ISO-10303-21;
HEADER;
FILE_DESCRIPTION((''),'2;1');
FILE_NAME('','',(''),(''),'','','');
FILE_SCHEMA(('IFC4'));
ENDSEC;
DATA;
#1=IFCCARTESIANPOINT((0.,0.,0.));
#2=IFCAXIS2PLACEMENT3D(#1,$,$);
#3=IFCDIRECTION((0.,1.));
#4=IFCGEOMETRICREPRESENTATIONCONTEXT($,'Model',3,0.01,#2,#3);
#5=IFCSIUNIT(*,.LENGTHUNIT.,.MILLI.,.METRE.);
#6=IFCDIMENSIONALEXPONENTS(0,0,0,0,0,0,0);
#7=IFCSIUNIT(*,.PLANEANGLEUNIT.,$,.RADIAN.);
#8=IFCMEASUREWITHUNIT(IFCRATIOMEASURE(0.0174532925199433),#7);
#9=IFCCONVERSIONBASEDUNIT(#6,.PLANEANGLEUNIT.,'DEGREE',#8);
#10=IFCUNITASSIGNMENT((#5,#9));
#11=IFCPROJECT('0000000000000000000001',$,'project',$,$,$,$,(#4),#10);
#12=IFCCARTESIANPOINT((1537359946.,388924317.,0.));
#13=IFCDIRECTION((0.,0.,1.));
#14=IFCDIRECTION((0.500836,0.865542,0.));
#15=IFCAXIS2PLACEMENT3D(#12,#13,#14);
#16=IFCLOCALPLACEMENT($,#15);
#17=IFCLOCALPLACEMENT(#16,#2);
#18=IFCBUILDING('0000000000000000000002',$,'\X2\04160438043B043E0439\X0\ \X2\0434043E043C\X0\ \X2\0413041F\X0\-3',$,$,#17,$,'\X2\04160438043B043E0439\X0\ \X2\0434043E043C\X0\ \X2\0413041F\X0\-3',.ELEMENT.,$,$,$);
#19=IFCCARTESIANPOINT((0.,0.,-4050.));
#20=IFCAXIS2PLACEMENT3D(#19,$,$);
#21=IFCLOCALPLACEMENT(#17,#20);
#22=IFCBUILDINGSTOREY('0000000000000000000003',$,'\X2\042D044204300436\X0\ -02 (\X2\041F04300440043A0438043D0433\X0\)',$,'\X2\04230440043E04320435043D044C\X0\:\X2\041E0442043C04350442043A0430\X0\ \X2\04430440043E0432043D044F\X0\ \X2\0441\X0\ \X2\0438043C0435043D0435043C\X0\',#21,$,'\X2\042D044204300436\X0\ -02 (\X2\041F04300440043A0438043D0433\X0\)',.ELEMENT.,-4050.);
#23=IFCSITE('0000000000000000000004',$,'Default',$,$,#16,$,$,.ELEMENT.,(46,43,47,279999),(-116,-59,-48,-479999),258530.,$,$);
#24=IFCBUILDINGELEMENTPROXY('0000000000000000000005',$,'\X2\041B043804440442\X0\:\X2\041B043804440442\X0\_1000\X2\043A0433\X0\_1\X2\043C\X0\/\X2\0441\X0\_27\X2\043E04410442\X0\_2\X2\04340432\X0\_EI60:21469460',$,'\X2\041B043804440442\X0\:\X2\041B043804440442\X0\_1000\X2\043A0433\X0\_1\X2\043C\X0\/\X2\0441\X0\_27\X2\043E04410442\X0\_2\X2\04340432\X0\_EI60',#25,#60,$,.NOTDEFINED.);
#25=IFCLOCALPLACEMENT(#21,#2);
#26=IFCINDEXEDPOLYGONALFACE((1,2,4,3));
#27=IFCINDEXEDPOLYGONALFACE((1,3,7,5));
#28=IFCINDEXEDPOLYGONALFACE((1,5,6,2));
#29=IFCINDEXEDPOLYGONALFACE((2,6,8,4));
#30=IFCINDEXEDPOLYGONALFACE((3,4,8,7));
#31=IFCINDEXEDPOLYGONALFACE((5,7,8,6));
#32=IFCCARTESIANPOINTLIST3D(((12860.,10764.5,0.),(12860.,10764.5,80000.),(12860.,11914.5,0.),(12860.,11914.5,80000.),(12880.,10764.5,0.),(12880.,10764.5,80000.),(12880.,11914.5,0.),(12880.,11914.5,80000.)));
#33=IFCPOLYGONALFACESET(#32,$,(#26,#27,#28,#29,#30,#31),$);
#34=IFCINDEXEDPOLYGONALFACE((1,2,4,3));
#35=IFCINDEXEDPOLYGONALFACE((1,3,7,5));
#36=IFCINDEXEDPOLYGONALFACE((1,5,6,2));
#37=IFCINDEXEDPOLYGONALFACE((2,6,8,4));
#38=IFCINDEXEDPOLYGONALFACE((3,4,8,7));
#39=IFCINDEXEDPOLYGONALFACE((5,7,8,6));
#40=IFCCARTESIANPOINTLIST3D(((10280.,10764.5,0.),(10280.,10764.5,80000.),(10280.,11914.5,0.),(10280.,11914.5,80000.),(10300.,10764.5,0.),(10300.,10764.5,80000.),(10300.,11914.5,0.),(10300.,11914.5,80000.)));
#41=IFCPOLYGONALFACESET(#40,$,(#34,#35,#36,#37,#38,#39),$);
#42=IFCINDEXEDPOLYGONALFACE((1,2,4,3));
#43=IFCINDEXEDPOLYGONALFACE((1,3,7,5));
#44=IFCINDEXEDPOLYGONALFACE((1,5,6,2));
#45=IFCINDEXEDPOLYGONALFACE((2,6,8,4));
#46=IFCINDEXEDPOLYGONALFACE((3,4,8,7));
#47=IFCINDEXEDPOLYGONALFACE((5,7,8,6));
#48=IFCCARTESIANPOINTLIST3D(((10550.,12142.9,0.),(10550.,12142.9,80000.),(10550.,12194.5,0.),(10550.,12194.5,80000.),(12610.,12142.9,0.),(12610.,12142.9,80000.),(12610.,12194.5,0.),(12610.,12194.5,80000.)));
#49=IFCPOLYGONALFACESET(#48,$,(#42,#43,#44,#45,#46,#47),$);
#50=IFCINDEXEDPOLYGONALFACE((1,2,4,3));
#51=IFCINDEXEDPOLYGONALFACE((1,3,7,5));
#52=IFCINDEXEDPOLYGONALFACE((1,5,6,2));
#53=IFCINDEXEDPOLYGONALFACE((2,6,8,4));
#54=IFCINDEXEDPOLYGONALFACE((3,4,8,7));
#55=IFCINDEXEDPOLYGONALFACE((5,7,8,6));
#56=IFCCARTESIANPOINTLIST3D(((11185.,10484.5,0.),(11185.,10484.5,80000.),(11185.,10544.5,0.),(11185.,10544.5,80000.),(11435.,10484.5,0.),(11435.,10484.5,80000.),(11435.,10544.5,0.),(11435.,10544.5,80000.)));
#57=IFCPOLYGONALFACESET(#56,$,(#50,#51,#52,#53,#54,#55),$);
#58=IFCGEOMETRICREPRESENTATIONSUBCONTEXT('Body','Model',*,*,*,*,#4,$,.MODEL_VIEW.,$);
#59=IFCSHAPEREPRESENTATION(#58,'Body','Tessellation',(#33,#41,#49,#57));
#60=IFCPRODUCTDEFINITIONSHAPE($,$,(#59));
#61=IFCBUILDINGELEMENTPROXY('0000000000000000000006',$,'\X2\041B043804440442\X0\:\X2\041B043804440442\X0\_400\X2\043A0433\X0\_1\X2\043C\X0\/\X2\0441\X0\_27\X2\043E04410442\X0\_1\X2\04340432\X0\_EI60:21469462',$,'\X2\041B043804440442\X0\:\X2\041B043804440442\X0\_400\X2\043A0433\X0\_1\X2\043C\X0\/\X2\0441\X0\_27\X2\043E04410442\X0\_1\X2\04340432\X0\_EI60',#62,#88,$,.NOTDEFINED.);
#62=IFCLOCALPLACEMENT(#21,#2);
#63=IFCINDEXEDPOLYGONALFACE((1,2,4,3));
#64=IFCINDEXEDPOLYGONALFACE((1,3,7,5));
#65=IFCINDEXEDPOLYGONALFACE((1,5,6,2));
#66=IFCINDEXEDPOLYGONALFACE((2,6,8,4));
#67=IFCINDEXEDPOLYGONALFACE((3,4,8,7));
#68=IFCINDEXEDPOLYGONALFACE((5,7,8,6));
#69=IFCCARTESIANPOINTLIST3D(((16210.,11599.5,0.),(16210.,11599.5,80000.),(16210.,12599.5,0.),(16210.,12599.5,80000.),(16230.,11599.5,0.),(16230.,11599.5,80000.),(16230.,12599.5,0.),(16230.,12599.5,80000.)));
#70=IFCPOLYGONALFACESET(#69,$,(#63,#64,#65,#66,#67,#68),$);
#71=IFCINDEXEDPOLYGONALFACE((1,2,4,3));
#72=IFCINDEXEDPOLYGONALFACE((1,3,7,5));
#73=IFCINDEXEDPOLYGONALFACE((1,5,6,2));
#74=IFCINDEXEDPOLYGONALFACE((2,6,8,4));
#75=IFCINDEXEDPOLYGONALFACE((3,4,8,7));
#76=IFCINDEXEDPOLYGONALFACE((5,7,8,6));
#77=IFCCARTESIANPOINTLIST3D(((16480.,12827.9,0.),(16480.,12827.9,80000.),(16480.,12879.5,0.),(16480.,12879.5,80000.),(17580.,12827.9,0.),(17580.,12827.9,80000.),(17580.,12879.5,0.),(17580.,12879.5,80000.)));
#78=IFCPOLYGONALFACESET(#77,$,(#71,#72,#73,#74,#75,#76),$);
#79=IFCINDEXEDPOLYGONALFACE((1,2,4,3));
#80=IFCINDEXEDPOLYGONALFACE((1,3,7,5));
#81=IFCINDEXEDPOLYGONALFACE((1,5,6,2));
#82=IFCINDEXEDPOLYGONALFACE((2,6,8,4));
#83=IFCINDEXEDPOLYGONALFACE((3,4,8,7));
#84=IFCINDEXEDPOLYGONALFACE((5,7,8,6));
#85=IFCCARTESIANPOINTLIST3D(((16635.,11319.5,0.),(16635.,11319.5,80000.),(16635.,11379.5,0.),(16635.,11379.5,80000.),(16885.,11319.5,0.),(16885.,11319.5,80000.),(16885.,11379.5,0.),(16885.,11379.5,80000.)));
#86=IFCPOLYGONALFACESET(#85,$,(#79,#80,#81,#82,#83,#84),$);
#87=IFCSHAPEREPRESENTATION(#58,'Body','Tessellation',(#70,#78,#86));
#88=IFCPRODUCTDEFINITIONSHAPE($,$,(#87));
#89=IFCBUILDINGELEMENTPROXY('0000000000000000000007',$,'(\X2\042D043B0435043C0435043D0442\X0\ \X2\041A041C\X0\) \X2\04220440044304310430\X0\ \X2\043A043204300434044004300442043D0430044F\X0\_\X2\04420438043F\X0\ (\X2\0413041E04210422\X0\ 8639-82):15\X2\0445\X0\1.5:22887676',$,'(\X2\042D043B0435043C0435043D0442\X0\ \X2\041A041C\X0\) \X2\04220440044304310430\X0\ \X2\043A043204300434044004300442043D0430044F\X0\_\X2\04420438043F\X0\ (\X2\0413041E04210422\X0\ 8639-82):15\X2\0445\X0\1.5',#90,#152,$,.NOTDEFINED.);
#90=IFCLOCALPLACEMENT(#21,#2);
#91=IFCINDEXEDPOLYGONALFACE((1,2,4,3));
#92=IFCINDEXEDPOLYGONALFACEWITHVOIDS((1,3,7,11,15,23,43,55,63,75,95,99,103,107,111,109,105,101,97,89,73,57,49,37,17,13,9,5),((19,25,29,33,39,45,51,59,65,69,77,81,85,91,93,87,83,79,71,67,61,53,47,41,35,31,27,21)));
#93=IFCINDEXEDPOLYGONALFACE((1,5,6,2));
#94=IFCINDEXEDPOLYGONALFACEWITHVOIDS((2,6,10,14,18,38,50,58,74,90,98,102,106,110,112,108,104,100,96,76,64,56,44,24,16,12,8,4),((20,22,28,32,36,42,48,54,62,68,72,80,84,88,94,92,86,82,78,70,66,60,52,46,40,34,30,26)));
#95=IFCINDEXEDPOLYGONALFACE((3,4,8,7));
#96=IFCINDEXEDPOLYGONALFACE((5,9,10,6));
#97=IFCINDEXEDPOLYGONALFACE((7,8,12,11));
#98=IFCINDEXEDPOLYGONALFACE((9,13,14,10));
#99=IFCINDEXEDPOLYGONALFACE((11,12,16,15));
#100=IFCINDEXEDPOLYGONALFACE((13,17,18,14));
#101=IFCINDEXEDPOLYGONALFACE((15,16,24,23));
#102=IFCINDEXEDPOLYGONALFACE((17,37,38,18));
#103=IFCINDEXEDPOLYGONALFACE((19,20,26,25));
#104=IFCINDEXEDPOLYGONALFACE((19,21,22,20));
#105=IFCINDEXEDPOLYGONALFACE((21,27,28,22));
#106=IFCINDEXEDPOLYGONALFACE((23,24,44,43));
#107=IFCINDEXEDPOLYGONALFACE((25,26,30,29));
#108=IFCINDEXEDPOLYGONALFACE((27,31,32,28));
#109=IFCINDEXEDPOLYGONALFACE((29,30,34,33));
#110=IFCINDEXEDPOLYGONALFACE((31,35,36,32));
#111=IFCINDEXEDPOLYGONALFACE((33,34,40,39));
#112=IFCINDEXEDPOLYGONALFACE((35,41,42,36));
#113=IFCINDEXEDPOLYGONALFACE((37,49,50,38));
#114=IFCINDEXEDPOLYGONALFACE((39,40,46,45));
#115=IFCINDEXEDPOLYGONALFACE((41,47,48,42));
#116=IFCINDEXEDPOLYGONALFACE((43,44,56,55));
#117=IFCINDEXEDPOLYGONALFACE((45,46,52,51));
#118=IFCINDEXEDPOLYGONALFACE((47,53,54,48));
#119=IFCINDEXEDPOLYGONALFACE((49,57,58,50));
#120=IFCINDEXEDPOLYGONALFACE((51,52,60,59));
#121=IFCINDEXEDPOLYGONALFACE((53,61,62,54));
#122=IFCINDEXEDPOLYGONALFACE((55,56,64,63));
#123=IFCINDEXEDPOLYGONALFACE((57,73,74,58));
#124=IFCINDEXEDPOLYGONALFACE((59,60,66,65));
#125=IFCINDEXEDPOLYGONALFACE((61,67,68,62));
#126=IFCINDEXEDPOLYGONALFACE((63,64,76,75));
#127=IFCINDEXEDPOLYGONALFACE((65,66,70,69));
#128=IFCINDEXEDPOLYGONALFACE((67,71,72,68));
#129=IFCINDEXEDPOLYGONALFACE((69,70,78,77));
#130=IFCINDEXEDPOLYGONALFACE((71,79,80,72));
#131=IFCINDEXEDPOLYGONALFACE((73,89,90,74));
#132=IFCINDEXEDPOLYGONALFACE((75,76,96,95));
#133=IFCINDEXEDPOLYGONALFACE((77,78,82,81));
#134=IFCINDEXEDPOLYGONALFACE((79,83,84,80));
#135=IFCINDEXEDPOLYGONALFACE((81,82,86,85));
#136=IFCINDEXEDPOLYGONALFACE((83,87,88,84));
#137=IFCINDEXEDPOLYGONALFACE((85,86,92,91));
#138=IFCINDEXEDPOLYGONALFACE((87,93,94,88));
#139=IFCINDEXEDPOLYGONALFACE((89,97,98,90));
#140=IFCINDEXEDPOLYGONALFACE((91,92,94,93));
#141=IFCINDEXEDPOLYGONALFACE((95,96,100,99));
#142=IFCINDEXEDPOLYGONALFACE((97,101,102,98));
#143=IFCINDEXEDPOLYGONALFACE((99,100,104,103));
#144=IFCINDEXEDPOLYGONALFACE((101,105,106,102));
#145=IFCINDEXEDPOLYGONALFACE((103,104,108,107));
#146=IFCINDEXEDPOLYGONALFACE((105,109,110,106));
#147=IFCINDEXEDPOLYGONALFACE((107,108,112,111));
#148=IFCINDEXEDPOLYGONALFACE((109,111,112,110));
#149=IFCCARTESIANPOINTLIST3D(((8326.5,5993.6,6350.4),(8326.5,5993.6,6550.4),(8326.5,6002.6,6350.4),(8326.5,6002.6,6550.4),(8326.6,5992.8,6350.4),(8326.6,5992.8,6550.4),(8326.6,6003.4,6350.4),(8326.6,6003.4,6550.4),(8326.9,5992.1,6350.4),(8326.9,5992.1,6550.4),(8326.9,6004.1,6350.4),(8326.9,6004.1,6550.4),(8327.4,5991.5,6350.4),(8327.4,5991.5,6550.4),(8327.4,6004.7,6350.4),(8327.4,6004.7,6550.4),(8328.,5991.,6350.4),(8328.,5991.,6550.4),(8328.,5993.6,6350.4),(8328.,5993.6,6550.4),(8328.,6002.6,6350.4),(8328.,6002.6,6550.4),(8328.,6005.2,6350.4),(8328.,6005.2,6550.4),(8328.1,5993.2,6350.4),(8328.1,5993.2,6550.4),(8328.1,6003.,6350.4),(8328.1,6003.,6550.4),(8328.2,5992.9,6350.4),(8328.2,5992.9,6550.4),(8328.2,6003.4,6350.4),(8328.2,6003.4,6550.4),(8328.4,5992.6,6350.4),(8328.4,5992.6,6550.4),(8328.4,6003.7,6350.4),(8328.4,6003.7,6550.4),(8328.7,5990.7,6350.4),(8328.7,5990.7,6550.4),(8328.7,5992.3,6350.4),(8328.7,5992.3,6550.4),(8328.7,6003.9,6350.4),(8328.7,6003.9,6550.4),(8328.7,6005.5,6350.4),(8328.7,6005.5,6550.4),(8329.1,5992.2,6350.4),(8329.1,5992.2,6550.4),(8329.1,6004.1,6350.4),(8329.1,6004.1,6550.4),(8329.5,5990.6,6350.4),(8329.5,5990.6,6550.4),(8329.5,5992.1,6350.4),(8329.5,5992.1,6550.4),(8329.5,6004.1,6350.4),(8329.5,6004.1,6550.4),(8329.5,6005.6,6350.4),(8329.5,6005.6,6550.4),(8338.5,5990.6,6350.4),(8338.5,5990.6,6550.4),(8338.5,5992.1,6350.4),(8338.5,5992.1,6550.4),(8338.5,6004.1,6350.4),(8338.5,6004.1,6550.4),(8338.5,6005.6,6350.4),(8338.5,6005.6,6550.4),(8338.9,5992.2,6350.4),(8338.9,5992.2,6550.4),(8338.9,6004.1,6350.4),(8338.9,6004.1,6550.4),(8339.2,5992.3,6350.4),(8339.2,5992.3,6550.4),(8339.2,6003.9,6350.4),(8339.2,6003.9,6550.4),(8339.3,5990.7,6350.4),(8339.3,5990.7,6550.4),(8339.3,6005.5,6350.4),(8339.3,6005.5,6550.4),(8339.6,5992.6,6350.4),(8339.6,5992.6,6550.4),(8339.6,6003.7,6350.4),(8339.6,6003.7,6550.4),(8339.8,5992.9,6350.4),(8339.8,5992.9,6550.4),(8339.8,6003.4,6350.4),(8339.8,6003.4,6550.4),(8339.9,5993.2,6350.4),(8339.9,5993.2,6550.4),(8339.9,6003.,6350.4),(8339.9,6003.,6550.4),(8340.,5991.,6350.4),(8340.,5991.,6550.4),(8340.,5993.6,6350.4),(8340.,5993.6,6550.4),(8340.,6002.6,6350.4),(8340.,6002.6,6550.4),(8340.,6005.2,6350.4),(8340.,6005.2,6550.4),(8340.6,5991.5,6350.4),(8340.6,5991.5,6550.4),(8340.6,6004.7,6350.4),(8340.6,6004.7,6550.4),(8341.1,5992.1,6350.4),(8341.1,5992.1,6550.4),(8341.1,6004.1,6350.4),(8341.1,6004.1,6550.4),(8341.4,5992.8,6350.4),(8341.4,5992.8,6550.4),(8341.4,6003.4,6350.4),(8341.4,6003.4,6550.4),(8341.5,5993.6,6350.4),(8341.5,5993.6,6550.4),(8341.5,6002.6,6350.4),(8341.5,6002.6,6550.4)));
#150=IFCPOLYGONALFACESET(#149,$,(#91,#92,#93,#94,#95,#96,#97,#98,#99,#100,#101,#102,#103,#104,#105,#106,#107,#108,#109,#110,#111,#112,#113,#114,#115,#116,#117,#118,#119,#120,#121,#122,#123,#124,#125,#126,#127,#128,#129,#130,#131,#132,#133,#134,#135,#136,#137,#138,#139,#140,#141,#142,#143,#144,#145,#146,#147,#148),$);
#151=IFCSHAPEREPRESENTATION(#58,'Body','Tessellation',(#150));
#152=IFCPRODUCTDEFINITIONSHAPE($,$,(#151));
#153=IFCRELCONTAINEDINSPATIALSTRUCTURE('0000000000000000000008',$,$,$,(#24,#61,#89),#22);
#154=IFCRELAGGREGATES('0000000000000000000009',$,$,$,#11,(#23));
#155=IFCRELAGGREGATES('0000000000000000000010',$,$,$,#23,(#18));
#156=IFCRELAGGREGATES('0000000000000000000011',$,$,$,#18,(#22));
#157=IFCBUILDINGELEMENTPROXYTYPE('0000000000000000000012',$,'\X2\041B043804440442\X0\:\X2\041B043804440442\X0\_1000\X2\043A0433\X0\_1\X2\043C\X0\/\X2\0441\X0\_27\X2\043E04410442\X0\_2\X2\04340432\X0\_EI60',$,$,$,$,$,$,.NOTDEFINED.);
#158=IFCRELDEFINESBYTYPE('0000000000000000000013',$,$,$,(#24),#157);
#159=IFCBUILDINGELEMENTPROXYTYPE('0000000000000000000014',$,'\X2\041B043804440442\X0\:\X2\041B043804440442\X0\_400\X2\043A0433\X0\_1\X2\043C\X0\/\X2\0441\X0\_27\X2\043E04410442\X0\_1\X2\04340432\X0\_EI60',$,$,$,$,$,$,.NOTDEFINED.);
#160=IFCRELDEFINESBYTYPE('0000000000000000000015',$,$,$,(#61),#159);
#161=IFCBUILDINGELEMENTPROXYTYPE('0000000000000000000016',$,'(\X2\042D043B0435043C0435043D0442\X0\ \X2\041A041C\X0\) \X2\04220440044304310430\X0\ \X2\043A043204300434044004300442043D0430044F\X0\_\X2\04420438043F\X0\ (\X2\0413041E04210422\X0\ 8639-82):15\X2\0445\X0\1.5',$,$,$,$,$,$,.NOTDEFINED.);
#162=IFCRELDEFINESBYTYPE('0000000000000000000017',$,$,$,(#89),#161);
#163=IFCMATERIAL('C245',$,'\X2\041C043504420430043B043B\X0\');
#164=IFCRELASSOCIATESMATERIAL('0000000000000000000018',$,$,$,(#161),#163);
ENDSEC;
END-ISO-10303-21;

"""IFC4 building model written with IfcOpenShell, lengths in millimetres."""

from ifc_helpers import new_model, entity, si_unit, converted_unit, direction, frame, frame_2d, origin, origin_2d_with_axis, place, context, subcontext, project, spatial, polyline, circle_curve, parameter, trimmed, segment, composite_curve, rectangle, outline, extrude, source, transform, mapped, material, type_object, type_shapes, element, save


model = new_model("IFC4")

# Units and contexts
model_context = context("Model", 3, precision=0.01, world=origin(), true_north=direction((0.0, 1.0)))
body_context = subcontext(model_context, "Body", "Model", "MODEL_VIEW")
ifc_project = project(units=[si_unit("LENGTHUNIT", "METRE", prefix="MILLI"), converted_unit("PLANEANGLEUNIT", "DEGREE", entity("IfcRatioMeasure", 0.0174532925199433), si_unit("PLANEANGLEUNIT", "RADIAN"), dimensions=[0, 0, 0, 0, 0, 0, 0])], contexts=[model_context])

# Site, building, storey
site_placement = place(None, frame((1537359946.0, 388924317.0, 0.0), z_axis=(0.0, 0.0, 1.0), x_axis=(0.500836, 0.865542, 0.0)))
site = spatial("IfcSite", under=ifc_project, at=site_placement, Name="Default", CompositionType="ELEMENT", RefLatitude=(46, 43, 47, 279999), RefLongitude=(-116, -59, -48, -479999), RefElevation=258530.0)
building_placement = place(site_placement, origin())
building = spatial("IfcBuilding", under=site, at=building_placement, Name="Жилой дом ГП-3", LongName="Жилой дом ГП-3", CompositionType="ELEMENT")
storey_placement = place(building_placement, frame((0.0, 0.0, -4050.0)))
storey = spatial("IfcBuildingStorey", under=building, at=storey_placement, Name="Этаж -02 (Паркинг)", ObjectType="Уровень:Отметка уровня с именем", LongName="Этаж -02 (Паркинг)", CompositionType="ELEMENT", Elevation=-4050.0)

# Building element proxies
building_element_proxy_type_1 = type_object("IfcBuildingElementProxyType", Name="Лифт:Лифт_1000кг_1м/с_27ост_2дв_EI60", PredefinedType="NOTDEFINED")
shared_shape_1 = source(origin(), body_context, "Body", "SweptSolid", [
    extrude(rectangle(XDim=1150.0, YDim=20.0, at=frame_2d((0.0, 0.0), x_axis=(1.0, 0.0))), frame((0.0, -1290.0, 0.0), z_axis=(0.0, 0.0, 1.0), x_axis=(-1.0, 0.0, 0.0)), (0.0, 0.0, 1.0), 80000.0),
    extrude(rectangle(XDim=20.0, YDim=1150.0, at=frame_2d((0.0, 0.0), x_axis=(1.0, 0.0))), frame((0.0, 1290.0, 0.0), z_axis=(0.0, 0.0, 1.0), x_axis=(0.0, 1.0, 0.0)), (0.0, 0.0, 1.0), 80000.0),
    extrude(rectangle(XDim=51.7, YDim=2060.0, at=frame_2d((0.0, 0.0), x_axis=(1.0, 0.0))), frame((829.2, 0.0, 0.0), z_axis=(0.0, 0.0, 1.0), x_axis=(-1.0, 0.0, 0.0)), (0.0, 0.0, 1.0), 80000.0),
    extrude(rectangle(XDim=60.0, YDim=250.0, at=origin_2d_with_axis()), frame((-825.0, 270.0, 0.0), z_axis=(0.0, 0.0, 1.0), x_axis=(-1.0, 0.0, 0.0)), (0.0, 0.0, 1.0), 80000.0),
])
type_shapes(building_element_proxy_type_1, [shared_shape_1])
for number, where, z_axis, x_axis, name in (
    (1, (11580.0, 11339.5, 0.0), (0.0, 0.0, 1.0), (0.0, 1.0, 0.0), "Лифт:Лифт_1000кг_1м/с_27ост_2дв_EI60:21469460"),
):
    element("IfcBuildingElementProxy", number, at=place(storey_placement, frame(where, z_axis=z_axis, x_axis=x_axis)), inside=storey, type_object=building_element_proxy_type_1, Name=name, ObjectType="Лифт:Лифт_1000кг_1м/с_27ост_2дв_EI60", PredefinedType="NOTDEFINED", context=body_context, shape_type="MappedRepresentation", body=[
        mapped(shared_shape_1, transform((0.0, 0.0, 0.0), scale=1.0)),
    ])
building_element_proxy_type_2 = type_object("IfcBuildingElementProxyType", Name="Лифт:Лифт_400кг_1м/с_27ост_1дв_EI60", PredefinedType="NOTDEFINED")
shared_shape_2 = source(origin(), body_context, "Body", "SweptSolid", [
    extrude(rectangle(XDim=20.0, YDim=1000.0, at=frame_2d((0.0, 0.0), x_axis=(1.0, 0.0))), frame((0.0, 810.0, 0.0), z_axis=(0.0, 0.0, 1.0), x_axis=(0.0, 1.0, 0.0)), (0.0, 0.0, 1.0), 80000.0),
    extrude(rectangle(XDim=51.7, YDim=1100.0, at=origin_2d_with_axis()), frame((754.2, 0.0, 0.0), z_axis=(0.0, 0.0, 1.0), x_axis=(-1.0, 0.0, 0.0)), (0.0, 0.0, 1.0), 80000.0),
    extrude(rectangle(XDim=60.0, YDim=250.0, at=origin_2d_with_axis()), frame((-750.0, 270.0, 0.0), z_axis=(0.0, 0.0, 1.0), x_axis=(-1.0, 0.0, 0.0)), (0.0, 0.0, 1.0), 80000.0),
])
type_shapes(building_element_proxy_type_2, [shared_shape_2])
proxy_1_placement = place(storey_placement, frame((17030.0, 12099.5, 0.0), z_axis=(0.0, 0.0, 1.0), x_axis=(0.0, 1.0, 0.0)))
element("IfcBuildingElementProxy", 2, at=proxy_1_placement, inside=storey, type_object=building_element_proxy_type_2, Name="Лифт:Лифт_400кг_1м/с_27ост_1дв_EI60:21469462", ObjectType="Лифт:Лифт_400кг_1м/с_27ост_1дв_EI60", PredefinedType="NOTDEFINED", context=body_context, shape_type="MappedRepresentation", body=[
    mapped(shared_shape_2, transform((0.0, 0.0, 0.0), scale=1.0)),
])
ifc_material_1 = material(Name="C245", Category="Металл")
building_element_proxy_type_3 = type_object("IfcBuildingElementProxyType", Name="(Элемент КМ) Труба квадратная_тип (ГОСТ 8639-82):15х1.5", PredefinedType="NOTDEFINED", material=ifc_material_1)
shared_shape_3 = source(origin(), body_context, "Body", "SweptSolid", [
    extrude(outline(composite_curve([segment(trimmed(circle_curve(frame_2d((4.5, -4.5), x_axis=(1.0, 0.0)), 3.0), [parameter(270.0)], [parameter(0.0)], True, "PARAMETER"), True, "CONTINUOUS"), segment(polyline([(7.5, -4.5), (7.5, 4.5)]), True, "CONTINUOUS"), segment(trimmed(circle_curve(frame_2d((4.5, 4.5), x_axis=(1.0, 0.0)), 3.0), [parameter(0.0)], [parameter(90.0)], True, "PARAMETER"), True, "CONTINUOUS"), segment(polyline([(4.5, 7.5), (-4.5, 7.5)]), True, "CONTINUOUS"), segment(trimmed(circle_curve(frame_2d((-4.5, 4.5), x_axis=(1.0, 0.0)), 3.0), [parameter(90.0)], [parameter(180.0)], True, "PARAMETER"), True, "CONTINUOUS"), segment(polyline([(-7.5, 4.5), (-7.5, -4.5)]), True, "CONTINUOUS"), segment(trimmed(circle_curve(frame_2d((-4.5, -4.5), x_axis=(1.0, 0.0)), 3.0), [parameter(180.0)], [parameter(270.0)], True, "PARAMETER"), True, "CONTINUOUS"), segment(polyline([(-4.5, -7.5), (4.5, -7.5)]), True, "CONTINUOUS")], self_intersect=False), holes=[composite_curve([segment(polyline([(4.5, -6.0), (-4.5, -6.0)]), True, "CONTINUOUS"), segment(trimmed(circle_curve(frame_2d((-4.5, -4.5), x_axis=(1.0, 0.0)), 1.5), [parameter(180.0)], [parameter(270.0)], True, "PARAMETER"), False, "CONTINUOUS"), segment(polyline([(-6.0, -4.5), (-6.0, 4.5)]), True, "CONTINUOUS"), segment(trimmed(circle_curve(frame_2d((-4.5, 4.5), x_axis=(1.0, 0.0)), 1.5), [parameter(90.0)], [parameter(180.0)], True, "PARAMETER"), False, "CONTINUOUS"), segment(polyline([(-4.5, 6.0), (4.5, 6.0)]), True, "CONTINUOUS"), segment(trimmed(circle_curve(frame_2d((4.5, 4.5), x_axis=(1.0, 0.0)), 1.5), [parameter(0.0)], [parameter(90.0)], True, "PARAMETER"), False, "CONTINUOUS"), segment(polyline([(6.0, 4.5), (6.0, -4.5)]), True, "CONTINUOUS"), segment(trimmed(circle_curve(frame_2d((4.5, -4.5), x_axis=(1.0, 0.0)), 1.5), [parameter(270.0)], [parameter(0.0)], True, "PARAMETER"), False, "CONTINUOUS")], self_intersect=False)]), frame((-100.0, 0.0, 0.0), z_axis=(1.0, 0.0, 0.0), x_axis=(0.0, -1.0, 0.0)), (0.0, 0.0, 1.0), 200.0),
])
type_shapes(building_element_proxy_type_3, [shared_shape_3])
proxy_2_placement = place(storey_placement, frame((8334.0, 5998.1, 6450.4), z_axis=(1.0, 0.0, 0.0), x_axis=(0.0, 0.0, 1.0)))
element("IfcBuildingElementProxy", 3, at=proxy_2_placement, inside=storey, type_object=building_element_proxy_type_3, Name="(Элемент КМ) Труба квадратная_тип (ГОСТ 8639-82):15х1.5:22887676", ObjectType="(Элемент КМ) Труба квадратная_тип (ГОСТ 8639-82):15х1.5", PredefinedType="NOTDEFINED", context=body_context, shape_type="MappedRepresentation", body=[
    mapped(shared_shape_3, transform((0.0, 0.0, 0.0), scale=1.0)),
])

save(model, "model.ifc")
